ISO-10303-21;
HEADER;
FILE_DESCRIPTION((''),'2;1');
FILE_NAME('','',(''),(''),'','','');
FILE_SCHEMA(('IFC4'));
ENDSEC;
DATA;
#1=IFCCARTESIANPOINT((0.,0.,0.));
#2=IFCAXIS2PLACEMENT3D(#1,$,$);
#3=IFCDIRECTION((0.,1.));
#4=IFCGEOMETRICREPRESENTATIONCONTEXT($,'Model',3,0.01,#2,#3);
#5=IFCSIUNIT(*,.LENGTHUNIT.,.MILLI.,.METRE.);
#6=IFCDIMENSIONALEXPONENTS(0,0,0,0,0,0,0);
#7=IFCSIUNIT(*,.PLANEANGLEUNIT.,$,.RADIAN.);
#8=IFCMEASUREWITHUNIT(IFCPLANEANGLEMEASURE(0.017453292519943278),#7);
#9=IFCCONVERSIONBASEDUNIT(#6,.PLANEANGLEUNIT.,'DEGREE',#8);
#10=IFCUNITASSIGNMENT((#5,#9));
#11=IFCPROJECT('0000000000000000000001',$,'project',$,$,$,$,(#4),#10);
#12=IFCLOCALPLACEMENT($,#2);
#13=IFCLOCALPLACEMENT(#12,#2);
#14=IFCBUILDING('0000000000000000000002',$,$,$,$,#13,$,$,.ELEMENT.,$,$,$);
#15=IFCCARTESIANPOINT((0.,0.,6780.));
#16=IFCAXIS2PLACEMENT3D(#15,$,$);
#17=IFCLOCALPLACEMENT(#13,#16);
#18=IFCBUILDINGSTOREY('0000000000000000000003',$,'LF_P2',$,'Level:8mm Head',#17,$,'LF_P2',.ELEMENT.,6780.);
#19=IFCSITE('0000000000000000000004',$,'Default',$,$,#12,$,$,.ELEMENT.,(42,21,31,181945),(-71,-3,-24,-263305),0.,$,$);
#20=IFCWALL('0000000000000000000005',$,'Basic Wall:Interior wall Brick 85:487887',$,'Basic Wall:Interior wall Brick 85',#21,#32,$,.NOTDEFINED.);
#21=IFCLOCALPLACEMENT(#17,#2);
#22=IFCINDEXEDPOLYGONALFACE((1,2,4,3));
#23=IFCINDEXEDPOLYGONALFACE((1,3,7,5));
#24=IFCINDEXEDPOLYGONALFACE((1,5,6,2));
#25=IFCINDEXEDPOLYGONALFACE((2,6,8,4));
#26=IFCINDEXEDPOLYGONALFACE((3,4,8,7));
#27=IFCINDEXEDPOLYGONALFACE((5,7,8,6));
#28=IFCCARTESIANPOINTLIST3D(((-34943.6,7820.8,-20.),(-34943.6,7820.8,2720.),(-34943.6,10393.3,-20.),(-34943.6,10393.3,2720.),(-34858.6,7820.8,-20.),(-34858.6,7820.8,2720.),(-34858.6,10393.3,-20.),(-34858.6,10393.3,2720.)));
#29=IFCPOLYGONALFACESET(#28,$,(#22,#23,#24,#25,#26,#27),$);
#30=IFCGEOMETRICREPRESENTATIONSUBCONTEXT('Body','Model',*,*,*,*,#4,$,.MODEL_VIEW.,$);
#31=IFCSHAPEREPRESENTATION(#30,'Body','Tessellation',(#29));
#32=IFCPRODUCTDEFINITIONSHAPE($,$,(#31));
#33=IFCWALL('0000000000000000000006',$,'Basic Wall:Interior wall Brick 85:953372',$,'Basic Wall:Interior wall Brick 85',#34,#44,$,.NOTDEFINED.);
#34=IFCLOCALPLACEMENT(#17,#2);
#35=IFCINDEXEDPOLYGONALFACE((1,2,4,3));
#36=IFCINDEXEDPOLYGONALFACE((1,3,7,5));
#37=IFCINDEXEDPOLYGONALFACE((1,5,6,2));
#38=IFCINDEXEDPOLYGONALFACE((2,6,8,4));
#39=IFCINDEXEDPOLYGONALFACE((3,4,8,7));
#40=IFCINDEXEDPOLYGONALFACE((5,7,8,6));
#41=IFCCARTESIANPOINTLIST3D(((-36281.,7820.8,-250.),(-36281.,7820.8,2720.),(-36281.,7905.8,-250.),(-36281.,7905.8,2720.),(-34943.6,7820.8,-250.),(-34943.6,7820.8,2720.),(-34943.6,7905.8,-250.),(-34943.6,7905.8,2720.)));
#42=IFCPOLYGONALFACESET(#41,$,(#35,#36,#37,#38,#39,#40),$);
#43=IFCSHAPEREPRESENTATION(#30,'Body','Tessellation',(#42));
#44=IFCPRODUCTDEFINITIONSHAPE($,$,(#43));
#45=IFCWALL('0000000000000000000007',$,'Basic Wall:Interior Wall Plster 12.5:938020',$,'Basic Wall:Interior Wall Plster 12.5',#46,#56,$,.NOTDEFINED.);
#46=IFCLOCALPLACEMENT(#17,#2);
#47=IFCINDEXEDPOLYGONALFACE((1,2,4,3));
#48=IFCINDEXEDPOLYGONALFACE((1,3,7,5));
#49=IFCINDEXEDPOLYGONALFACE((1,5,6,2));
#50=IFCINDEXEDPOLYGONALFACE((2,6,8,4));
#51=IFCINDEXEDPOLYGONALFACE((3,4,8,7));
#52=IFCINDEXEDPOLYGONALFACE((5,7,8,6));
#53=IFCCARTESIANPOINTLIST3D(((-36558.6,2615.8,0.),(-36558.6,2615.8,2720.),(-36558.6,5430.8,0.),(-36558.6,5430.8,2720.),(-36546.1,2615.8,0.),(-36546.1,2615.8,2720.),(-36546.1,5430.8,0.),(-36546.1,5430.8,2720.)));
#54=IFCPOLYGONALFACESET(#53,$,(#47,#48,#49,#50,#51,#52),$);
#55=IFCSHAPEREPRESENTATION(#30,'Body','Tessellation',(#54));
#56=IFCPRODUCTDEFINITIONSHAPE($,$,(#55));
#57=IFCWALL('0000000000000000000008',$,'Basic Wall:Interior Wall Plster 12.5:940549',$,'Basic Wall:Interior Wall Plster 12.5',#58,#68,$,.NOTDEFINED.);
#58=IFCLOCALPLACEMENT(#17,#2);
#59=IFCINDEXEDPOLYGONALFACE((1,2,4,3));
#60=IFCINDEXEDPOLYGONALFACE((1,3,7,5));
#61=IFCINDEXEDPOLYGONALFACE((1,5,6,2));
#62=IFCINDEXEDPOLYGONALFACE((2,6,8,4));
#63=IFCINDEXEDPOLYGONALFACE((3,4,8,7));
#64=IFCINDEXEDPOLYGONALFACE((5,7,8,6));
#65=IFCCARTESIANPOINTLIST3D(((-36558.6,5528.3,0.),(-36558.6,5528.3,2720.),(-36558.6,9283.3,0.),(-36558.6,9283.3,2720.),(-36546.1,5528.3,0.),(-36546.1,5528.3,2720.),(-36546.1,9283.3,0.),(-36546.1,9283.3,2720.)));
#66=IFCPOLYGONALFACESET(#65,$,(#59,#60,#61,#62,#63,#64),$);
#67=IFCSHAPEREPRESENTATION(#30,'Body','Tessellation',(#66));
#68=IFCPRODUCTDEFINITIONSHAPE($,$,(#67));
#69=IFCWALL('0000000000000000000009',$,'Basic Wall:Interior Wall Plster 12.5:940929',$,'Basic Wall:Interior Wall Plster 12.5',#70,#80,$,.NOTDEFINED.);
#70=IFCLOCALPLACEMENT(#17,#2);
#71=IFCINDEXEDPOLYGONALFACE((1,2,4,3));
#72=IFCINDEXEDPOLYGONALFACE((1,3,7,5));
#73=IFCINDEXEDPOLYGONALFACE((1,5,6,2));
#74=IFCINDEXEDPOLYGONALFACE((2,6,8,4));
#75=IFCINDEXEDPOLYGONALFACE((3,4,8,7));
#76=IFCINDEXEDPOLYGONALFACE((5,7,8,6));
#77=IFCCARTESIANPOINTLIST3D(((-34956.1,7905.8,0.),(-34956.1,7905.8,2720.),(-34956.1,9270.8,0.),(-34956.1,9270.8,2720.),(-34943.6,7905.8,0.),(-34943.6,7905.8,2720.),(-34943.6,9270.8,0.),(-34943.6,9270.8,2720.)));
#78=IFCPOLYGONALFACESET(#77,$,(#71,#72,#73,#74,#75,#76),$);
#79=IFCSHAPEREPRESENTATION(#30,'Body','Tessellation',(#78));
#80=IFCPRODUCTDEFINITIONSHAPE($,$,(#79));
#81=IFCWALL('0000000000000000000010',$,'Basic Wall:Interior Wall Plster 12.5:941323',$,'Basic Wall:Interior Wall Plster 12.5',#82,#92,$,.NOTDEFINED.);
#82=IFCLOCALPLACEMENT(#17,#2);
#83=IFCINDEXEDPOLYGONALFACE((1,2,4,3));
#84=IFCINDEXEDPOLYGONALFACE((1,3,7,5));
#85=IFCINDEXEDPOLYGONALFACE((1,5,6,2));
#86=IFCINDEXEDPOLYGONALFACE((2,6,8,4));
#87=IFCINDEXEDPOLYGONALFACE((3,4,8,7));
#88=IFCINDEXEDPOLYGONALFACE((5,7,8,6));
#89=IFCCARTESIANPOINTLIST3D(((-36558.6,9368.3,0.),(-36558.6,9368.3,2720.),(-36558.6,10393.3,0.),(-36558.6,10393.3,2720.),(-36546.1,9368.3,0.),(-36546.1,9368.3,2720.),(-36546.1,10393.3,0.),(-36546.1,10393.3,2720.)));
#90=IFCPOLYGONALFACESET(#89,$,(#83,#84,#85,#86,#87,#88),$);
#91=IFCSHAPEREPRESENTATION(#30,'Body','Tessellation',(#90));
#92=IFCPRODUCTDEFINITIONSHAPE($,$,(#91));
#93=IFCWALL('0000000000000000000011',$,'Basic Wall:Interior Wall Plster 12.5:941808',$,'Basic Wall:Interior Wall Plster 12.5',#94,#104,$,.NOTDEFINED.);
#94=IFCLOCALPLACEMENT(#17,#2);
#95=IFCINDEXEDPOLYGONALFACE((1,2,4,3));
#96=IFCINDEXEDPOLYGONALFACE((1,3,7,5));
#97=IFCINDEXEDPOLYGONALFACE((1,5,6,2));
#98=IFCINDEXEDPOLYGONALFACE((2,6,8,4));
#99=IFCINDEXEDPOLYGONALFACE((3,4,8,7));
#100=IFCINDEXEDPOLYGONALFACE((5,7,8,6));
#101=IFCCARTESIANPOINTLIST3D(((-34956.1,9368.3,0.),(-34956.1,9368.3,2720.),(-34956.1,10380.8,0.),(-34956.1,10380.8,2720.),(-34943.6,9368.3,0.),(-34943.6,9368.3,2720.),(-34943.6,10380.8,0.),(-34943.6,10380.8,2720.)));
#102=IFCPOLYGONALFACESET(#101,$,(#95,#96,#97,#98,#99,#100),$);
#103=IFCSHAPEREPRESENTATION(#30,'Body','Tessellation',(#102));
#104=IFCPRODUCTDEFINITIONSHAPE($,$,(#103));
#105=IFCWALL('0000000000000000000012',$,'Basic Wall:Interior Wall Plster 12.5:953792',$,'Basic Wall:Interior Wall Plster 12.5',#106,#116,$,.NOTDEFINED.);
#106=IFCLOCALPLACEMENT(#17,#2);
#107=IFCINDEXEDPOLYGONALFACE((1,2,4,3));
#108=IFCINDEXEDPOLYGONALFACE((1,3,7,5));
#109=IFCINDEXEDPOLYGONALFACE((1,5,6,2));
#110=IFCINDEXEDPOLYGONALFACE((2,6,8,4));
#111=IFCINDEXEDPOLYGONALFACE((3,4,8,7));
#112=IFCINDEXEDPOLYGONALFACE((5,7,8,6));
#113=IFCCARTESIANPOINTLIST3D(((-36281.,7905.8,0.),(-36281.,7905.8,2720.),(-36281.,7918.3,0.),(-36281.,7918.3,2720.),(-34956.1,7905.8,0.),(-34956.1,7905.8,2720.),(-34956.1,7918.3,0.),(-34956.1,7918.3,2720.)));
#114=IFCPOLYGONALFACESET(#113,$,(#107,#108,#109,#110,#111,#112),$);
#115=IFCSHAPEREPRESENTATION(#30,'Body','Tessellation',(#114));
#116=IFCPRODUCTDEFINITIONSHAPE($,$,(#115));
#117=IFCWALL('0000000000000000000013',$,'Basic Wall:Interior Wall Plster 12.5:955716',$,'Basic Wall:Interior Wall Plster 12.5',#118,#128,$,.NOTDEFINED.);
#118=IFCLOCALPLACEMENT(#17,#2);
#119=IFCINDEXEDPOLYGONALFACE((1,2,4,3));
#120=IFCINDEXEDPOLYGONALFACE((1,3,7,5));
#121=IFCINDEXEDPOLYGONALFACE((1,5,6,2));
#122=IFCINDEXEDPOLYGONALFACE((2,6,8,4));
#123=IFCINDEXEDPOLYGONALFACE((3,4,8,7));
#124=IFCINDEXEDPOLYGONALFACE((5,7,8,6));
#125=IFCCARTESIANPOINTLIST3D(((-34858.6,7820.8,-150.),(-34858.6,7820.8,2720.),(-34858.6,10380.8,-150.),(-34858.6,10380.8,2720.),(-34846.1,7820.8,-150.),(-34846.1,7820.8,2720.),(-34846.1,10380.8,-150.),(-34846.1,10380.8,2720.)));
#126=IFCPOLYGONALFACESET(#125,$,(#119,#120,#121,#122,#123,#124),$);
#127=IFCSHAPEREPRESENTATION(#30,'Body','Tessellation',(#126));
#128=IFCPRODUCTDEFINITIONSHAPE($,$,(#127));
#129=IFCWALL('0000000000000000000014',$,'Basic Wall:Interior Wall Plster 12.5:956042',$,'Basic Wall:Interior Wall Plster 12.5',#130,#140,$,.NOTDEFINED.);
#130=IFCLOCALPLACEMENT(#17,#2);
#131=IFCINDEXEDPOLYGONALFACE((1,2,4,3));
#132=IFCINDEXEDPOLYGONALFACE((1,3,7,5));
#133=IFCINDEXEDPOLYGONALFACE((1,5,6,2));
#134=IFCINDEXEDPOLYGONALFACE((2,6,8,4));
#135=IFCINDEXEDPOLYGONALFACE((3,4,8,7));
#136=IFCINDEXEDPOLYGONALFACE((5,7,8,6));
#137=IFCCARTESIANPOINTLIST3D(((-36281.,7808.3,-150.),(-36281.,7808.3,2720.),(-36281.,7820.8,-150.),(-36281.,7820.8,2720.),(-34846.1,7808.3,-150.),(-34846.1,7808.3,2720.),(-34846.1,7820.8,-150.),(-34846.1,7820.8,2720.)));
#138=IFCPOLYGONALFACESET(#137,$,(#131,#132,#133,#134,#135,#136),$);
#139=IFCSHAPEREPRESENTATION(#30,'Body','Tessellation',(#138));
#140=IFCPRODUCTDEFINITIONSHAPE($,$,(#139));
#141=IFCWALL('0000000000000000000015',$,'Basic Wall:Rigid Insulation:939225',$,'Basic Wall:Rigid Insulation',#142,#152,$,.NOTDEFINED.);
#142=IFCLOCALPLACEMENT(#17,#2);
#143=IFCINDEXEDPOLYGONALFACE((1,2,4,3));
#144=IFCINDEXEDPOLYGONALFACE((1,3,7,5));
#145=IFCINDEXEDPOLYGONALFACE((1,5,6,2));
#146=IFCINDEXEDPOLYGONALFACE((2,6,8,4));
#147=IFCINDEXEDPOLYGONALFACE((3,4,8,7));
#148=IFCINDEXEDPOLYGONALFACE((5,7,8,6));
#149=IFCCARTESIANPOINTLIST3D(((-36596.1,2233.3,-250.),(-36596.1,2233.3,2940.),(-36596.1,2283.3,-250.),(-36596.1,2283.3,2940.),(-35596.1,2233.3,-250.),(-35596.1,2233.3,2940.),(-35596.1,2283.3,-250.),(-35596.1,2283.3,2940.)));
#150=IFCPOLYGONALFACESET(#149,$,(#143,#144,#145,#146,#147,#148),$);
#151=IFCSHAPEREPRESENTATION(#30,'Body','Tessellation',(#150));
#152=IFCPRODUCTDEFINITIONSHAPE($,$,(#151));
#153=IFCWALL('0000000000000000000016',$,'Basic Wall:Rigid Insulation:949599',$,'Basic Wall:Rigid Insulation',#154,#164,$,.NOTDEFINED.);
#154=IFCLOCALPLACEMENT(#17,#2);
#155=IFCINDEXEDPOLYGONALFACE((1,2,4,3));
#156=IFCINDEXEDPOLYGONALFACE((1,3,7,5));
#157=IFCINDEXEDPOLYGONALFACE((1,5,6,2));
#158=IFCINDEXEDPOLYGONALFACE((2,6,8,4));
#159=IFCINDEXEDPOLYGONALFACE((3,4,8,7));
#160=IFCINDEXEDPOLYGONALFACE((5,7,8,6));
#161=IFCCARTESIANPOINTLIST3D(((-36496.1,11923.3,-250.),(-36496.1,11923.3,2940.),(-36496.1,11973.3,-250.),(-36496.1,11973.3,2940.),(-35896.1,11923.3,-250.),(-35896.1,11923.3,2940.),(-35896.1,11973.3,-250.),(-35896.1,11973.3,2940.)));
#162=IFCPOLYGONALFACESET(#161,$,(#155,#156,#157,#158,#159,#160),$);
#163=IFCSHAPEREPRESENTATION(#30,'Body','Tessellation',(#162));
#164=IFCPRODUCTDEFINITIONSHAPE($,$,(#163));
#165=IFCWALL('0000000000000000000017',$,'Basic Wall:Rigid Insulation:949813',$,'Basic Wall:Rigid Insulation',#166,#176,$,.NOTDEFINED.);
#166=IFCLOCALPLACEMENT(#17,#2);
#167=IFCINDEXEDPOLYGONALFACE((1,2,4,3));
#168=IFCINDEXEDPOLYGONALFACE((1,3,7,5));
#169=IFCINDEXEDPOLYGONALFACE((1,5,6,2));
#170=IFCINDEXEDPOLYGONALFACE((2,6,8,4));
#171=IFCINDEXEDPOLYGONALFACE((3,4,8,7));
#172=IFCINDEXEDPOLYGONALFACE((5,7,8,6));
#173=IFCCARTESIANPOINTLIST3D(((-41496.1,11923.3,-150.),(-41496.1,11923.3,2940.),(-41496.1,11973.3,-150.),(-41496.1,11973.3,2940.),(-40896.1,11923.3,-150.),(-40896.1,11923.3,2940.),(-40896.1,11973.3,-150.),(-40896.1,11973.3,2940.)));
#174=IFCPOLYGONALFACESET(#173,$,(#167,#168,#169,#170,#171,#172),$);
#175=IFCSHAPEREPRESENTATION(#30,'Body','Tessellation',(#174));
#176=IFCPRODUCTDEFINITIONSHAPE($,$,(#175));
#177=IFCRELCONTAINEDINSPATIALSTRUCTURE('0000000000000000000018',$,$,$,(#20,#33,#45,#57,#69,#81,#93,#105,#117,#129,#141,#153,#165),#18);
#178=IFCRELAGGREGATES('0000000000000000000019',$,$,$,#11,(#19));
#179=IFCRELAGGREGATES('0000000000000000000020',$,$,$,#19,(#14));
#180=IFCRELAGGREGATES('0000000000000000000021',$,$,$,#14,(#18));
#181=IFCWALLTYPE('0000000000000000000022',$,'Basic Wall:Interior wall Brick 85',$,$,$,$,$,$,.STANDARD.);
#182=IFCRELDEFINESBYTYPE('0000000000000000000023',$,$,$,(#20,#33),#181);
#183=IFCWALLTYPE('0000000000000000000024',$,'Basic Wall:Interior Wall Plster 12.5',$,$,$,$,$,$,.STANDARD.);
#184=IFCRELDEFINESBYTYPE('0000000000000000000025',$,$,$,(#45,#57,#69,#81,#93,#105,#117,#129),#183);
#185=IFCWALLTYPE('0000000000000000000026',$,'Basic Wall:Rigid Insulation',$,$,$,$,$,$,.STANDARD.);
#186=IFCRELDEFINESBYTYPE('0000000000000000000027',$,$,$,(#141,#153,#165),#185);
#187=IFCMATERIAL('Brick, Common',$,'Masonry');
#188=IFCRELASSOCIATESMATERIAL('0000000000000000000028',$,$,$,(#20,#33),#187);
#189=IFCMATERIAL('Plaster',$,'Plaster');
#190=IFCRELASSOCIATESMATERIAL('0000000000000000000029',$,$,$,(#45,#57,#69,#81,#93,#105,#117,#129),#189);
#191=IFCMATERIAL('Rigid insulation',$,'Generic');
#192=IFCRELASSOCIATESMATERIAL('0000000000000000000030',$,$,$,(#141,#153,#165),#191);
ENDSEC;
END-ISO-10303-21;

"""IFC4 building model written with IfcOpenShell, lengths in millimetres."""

from ifc_helpers import new_model, entity, si_unit, converted_unit, direction, frame, origin, place, context, subcontext, project, spatial, indexed_curve, outline, extrude, material, type_object, element, save


model = new_model("IFC4")

# Units and contexts
model_context = context("Model", 3, precision=0.01, world=origin(), true_north=direction((0.0, 1.0)))
body_context = subcontext(model_context, "Body", "Model", "MODEL_VIEW")
ifc_project = project(units=[si_unit("LENGTHUNIT", "METRE", prefix="MILLI"), converted_unit("PLANEANGLEUNIT", "DEGREE", entity("IfcPlaneAngleMeasure", 0.017453292519943278), si_unit("PLANEANGLEUNIT", "RADIAN"), dimensions=[0, 0, 0, 0, 0, 0, 0])], contexts=[model_context])

# Site, building, storey
site_placement = place(None, origin())
site = spatial("IfcSite", under=ifc_project, at=site_placement, Name="Default", CompositionType="ELEMENT", RefLatitude=(42, 21, 31, 181945), RefLongitude=(-71, -3, -24, -263305), RefElevation=0.0)
building_placement = place(site_placement, origin())
building = spatial("IfcBuilding", under=site, at=building_placement, CompositionType="ELEMENT")
storey_placement = place(building_placement, frame((0.0, 0.0, 6780.0)))
storey = spatial("IfcBuildingStorey", under=building, at=storey_placement, Name="LF_P2", ObjectType="Level:8mm Head", LongName="LF_P2", CompositionType="ELEMENT", Elevation=6780.0)

# Walls
ifc_material_1 = material(Name="Brick, Common", Category="Masonry")
wall_type_1 = type_object("IfcWallType", Name="Basic Wall:Interior wall Brick 85", PredefinedType="STANDARD")
wall_1_placement = place(storey_placement, frame((-34901.1, 10393.3, -20.0), z_axis=(0.0, 0.0, 1.0), x_axis=(0.0, -1.0, 0.0)))
element("IfcWall", 1, at=wall_1_placement, inside=storey, type_object=wall_type_1, material=ifc_material_1, Name="Basic Wall:Interior wall Brick 85:487887", ObjectType="Basic Wall:Interior wall Brick 85", PredefinedType="NOTDEFINED", context=body_context, shape_type="SweptSolid", body=[
    extrude(outline(indexed_curve([(2572.5, 42.5), (0.0, 42.5), (0.0, -42.5), (2572.5, -42.5), (2572.5, 42.5)], self_intersect=False)), origin(), (0.0, 0.0, 1.0), 2740.0),
])
wall_2_placement = place(storey_placement, frame((-34943.6, 7863.3, -250.0), z_axis=(0.0, 0.0, 1.0), x_axis=(-1.0, 0.0, 0.0)))
element("IfcWall", 2, at=wall_2_placement, inside=storey, type_object=wall_type_1, material=ifc_material_1, Name="Basic Wall:Interior wall Brick 85:953372", ObjectType="Basic Wall:Interior wall Brick 85", PredefinedType="NOTDEFINED", context=body_context, shape_type="SweptSolid", body=[
    extrude(outline(indexed_curve([(1337.4, 42.5), (0.0, 42.5), (0.0, -42.5), (1337.4, -42.5), (1337.4, 42.5)], self_intersect=False)), origin(), (0.0, 0.0, 1.0), 2970.0),
])
ifc_material_2 = material(Name="Plaster", Category="Plaster")
wall_type_2 = type_object("IfcWallType", Name="Basic Wall:Interior Wall Plster 12.5", PredefinedType="STANDARD")
wall_3_placement = place(storey_placement, frame((-36552.4, 2615.8, 0.0), z_axis=(0.0, 0.0, 1.0), x_axis=(0.0, 1.0, 0.0)))
element("IfcWall", 3, at=wall_3_placement, inside=storey, type_object=wall_type_2, material=ifc_material_2, Name="Basic Wall:Interior Wall Plster 12.5:938020", ObjectType="Basic Wall:Interior Wall Plster 12.5", PredefinedType="NOTDEFINED", context=body_context, shape_type="SweptSolid", body=[
    extrude(outline(indexed_curve([(2815.0, 6.2), (0.0, 6.2), (0.0, -6.2), (2815.0, -6.2), (2815.0, 6.2)], self_intersect=False)), origin(), (0.0, 0.0, 1.0), 2720.0),
])
wall_4_placement = place(storey_placement, frame((-36552.4, 5528.3, 0.0), z_axis=(0.0, 0.0, 1.0), x_axis=(0.0, 1.0, 0.0)))
element("IfcWall", 4, at=wall_4_placement, inside=storey, type_object=wall_type_2, material=ifc_material_2, Name="Basic Wall:Interior Wall Plster 12.5:940549", ObjectType="Basic Wall:Interior Wall Plster 12.5", PredefinedType="NOTDEFINED", context=body_context, shape_type="SweptSolid", body=[
    extrude(outline(indexed_curve([(3755.0, 6.2), (0.0, 6.2), (0.0, -6.2), (3755.0, -6.2), (3755.0, 6.2)], self_intersect=False)), origin(), (0.0, 0.0, 1.0), 2720.0),
])
wall_5_placement = place(storey_placement, frame((-34949.9, 9270.8, 0.0), z_axis=(0.0, 0.0, 1.0), x_axis=(0.0, -1.0, 0.0)))
element("IfcWall", 5, at=wall_5_placement, inside=storey, type_object=wall_type_2, material=ifc_material_2, Name="Basic Wall:Interior Wall Plster 12.5:940929", ObjectType="Basic Wall:Interior Wall Plster 12.5", PredefinedType="NOTDEFINED", context=body_context, shape_type="SweptSolid", body=[
    extrude(outline(indexed_curve([(1365.0, 6.2), (0.0, 6.2), (0.0, -6.2), (1365.0, -6.2), (1365.0, 6.2)], self_intersect=False)), origin(), (0.0, 0.0, 1.0), 2720.0),
])
wall_6_placement = place(storey_placement, frame((-36552.4, 9368.3, 0.0), z_axis=(0.0, 0.0, 1.0), x_axis=(0.0, 1.0, 0.0)))
element("IfcWall", 6, at=wall_6_placement, inside=storey, type_object=wall_type_2, material=ifc_material_2, Name="Basic Wall:Interior Wall Plster 12.5:941323", ObjectType="Basic Wall:Interior Wall Plster 12.5", PredefinedType="NOTDEFINED", context=body_context, shape_type="SweptSolid", body=[
    extrude(outline(indexed_curve([(1025.0, 6.2), (0.0, 6.2), (0.0, -6.2), (1025.0, -6.2), (1025.0, 6.2)], self_intersect=False)), origin(), (0.0, 0.0, 1.0), 2720.0),
])
wall_7_placement = place(storey_placement, frame((-34949.9, 10380.8, 0.0), z_axis=(0.0, 0.0, 1.0), x_axis=(0.0, -1.0, 0.0)))
element("IfcWall", 7, at=wall_7_placement, inside=storey, type_object=wall_type_2, material=ifc_material_2, Name="Basic Wall:Interior Wall Plster 12.5:941808", ObjectType="Basic Wall:Interior Wall Plster 12.5", PredefinedType="NOTDEFINED", context=body_context, shape_type="SweptSolid", body=[
    extrude(outline(indexed_curve([(1012.5, 6.2), (0.0, 6.2), (0.0, -6.2), (1012.5, -6.2), (1012.5, 6.2)], self_intersect=False)), origin(), (0.0, 0.0, 1.0), 2720.0),
])
wall_8_placement = place(storey_placement, frame((-34956.1, 7912.1, 0.0), z_axis=(0.0, 0.0, 1.0), x_axis=(-1.0, 0.0, 0.0)))
element("IfcWall", 8, at=wall_8_placement, inside=storey, type_object=wall_type_2, material=ifc_material_2, Name="Basic Wall:Interior Wall Plster 12.5:953792", ObjectType="Basic Wall:Interior Wall Plster 12.5", PredefinedType="NOTDEFINED", context=body_context, shape_type="SweptSolid", body=[
    extrude(outline(indexed_curve([(1324.9, 6.2), (0.0, 6.2), (0.0, -6.2), (1324.9, -6.2), (1324.9, 6.2)], self_intersect=False)), origin(), (0.0, 0.0, 1.0), 2720.0),
])
wall_9_placement = place(storey_placement, frame((-34852.4, 10380.8, -150.0), z_axis=(0.0, 0.0, 1.0), x_axis=(0.0, -1.0, 0.0)))
element("IfcWall", 9, at=wall_9_placement, inside=storey, type_object=wall_type_2, material=ifc_material_2, Name="Basic Wall:Interior Wall Plster 12.5:955716", ObjectType="Basic Wall:Interior Wall Plster 12.5", PredefinedType="NOTDEFINED", context=body_context, shape_type="SweptSolid", body=[
    extrude(outline(indexed_curve([(2560.0, 6.2), (0.0, 6.2), (0.0, -6.2), (2560.0, -6.2), (2560.0, 6.2)], self_intersect=False)), origin(), (0.0, 0.0, 1.0), 2870.0),
])
wall_10_placement = place(storey_placement, frame((-36281.0, 7814.6, -150.0)))
element("IfcWall", 10, at=wall_10_placement, inside=storey, type_object=wall_type_2, material=ifc_material_2, Name="Basic Wall:Interior Wall Plster 12.5:956042", ObjectType="Basic Wall:Interior Wall Plster 12.5", PredefinedType="NOTDEFINED", context=body_context, shape_type="SweptSolid", body=[
    extrude(outline(indexed_curve([(1434.9, 6.2), (0.0, 6.2), (0.0, -6.2), (1434.9, -6.2), (1434.9, 6.2)], self_intersect=False)), origin(), (0.0, 0.0, 1.0), 2870.0),
])
ifc_material_3 = material(Name="Rigid insulation", Category="Generic")
wall_type_3 = type_object("IfcWallType", Name="Basic Wall:Rigid Insulation", PredefinedType="STANDARD")
wall_11_placement = place(storey_placement, frame((-36596.1, 2258.3, -250.0)))
element("IfcWall", 11, at=wall_11_placement, inside=storey, type_object=wall_type_3, material=ifc_material_3, Name="Basic Wall:Rigid Insulation:939225", ObjectType="Basic Wall:Rigid Insulation", PredefinedType="NOTDEFINED", context=body_context, shape_type="SweptSolid", body=[
    extrude(outline(indexed_curve([(1000.0, 25.0), (0.0, 25.0), (0.0, -25.0), (1000.0, -25.0), (1000.0, 25.0)], self_intersect=False)), origin(), (0.0, 0.0, 1.0), 3190.0),
])
wall_12_placement = place(storey_placement, frame((-36496.1, 11948.3, -250.0)))
element("IfcWall", 12, at=wall_12_placement, inside=storey, type_object=wall_type_3, material=ifc_material_3, Name="Basic Wall:Rigid Insulation:949599", ObjectType="Basic Wall:Rigid Insulation", PredefinedType="NOTDEFINED", context=body_context, shape_type="SweptSolid", body=[
    extrude(outline(indexed_curve([(600.0, 25.0), (0.0, 25.0), (0.0, -25.0), (600.0, -25.0), (600.0, 25.0)], self_intersect=False)), origin(), (0.0, 0.0, 1.0), 3190.0),
])
wall_13_placement = place(storey_placement, frame((-41496.1, 11948.3, -150.0)))
element("IfcWall", 13, at=wall_13_placement, inside=storey, type_object=wall_type_3, material=ifc_material_3, Name="Basic Wall:Rigid Insulation:949813", ObjectType="Basic Wall:Rigid Insulation", PredefinedType="NOTDEFINED", context=body_context, shape_type="SweptSolid", body=[
    extrude(outline(indexed_curve([(600.0, 25.0), (0.0, 25.0), (0.0, -25.0), (600.0, -25.0), (600.0, 25.0)], self_intersect=False)), origin(), (0.0, 0.0, 1.0), 3090.0),
])

save(model, "model.ifc")
